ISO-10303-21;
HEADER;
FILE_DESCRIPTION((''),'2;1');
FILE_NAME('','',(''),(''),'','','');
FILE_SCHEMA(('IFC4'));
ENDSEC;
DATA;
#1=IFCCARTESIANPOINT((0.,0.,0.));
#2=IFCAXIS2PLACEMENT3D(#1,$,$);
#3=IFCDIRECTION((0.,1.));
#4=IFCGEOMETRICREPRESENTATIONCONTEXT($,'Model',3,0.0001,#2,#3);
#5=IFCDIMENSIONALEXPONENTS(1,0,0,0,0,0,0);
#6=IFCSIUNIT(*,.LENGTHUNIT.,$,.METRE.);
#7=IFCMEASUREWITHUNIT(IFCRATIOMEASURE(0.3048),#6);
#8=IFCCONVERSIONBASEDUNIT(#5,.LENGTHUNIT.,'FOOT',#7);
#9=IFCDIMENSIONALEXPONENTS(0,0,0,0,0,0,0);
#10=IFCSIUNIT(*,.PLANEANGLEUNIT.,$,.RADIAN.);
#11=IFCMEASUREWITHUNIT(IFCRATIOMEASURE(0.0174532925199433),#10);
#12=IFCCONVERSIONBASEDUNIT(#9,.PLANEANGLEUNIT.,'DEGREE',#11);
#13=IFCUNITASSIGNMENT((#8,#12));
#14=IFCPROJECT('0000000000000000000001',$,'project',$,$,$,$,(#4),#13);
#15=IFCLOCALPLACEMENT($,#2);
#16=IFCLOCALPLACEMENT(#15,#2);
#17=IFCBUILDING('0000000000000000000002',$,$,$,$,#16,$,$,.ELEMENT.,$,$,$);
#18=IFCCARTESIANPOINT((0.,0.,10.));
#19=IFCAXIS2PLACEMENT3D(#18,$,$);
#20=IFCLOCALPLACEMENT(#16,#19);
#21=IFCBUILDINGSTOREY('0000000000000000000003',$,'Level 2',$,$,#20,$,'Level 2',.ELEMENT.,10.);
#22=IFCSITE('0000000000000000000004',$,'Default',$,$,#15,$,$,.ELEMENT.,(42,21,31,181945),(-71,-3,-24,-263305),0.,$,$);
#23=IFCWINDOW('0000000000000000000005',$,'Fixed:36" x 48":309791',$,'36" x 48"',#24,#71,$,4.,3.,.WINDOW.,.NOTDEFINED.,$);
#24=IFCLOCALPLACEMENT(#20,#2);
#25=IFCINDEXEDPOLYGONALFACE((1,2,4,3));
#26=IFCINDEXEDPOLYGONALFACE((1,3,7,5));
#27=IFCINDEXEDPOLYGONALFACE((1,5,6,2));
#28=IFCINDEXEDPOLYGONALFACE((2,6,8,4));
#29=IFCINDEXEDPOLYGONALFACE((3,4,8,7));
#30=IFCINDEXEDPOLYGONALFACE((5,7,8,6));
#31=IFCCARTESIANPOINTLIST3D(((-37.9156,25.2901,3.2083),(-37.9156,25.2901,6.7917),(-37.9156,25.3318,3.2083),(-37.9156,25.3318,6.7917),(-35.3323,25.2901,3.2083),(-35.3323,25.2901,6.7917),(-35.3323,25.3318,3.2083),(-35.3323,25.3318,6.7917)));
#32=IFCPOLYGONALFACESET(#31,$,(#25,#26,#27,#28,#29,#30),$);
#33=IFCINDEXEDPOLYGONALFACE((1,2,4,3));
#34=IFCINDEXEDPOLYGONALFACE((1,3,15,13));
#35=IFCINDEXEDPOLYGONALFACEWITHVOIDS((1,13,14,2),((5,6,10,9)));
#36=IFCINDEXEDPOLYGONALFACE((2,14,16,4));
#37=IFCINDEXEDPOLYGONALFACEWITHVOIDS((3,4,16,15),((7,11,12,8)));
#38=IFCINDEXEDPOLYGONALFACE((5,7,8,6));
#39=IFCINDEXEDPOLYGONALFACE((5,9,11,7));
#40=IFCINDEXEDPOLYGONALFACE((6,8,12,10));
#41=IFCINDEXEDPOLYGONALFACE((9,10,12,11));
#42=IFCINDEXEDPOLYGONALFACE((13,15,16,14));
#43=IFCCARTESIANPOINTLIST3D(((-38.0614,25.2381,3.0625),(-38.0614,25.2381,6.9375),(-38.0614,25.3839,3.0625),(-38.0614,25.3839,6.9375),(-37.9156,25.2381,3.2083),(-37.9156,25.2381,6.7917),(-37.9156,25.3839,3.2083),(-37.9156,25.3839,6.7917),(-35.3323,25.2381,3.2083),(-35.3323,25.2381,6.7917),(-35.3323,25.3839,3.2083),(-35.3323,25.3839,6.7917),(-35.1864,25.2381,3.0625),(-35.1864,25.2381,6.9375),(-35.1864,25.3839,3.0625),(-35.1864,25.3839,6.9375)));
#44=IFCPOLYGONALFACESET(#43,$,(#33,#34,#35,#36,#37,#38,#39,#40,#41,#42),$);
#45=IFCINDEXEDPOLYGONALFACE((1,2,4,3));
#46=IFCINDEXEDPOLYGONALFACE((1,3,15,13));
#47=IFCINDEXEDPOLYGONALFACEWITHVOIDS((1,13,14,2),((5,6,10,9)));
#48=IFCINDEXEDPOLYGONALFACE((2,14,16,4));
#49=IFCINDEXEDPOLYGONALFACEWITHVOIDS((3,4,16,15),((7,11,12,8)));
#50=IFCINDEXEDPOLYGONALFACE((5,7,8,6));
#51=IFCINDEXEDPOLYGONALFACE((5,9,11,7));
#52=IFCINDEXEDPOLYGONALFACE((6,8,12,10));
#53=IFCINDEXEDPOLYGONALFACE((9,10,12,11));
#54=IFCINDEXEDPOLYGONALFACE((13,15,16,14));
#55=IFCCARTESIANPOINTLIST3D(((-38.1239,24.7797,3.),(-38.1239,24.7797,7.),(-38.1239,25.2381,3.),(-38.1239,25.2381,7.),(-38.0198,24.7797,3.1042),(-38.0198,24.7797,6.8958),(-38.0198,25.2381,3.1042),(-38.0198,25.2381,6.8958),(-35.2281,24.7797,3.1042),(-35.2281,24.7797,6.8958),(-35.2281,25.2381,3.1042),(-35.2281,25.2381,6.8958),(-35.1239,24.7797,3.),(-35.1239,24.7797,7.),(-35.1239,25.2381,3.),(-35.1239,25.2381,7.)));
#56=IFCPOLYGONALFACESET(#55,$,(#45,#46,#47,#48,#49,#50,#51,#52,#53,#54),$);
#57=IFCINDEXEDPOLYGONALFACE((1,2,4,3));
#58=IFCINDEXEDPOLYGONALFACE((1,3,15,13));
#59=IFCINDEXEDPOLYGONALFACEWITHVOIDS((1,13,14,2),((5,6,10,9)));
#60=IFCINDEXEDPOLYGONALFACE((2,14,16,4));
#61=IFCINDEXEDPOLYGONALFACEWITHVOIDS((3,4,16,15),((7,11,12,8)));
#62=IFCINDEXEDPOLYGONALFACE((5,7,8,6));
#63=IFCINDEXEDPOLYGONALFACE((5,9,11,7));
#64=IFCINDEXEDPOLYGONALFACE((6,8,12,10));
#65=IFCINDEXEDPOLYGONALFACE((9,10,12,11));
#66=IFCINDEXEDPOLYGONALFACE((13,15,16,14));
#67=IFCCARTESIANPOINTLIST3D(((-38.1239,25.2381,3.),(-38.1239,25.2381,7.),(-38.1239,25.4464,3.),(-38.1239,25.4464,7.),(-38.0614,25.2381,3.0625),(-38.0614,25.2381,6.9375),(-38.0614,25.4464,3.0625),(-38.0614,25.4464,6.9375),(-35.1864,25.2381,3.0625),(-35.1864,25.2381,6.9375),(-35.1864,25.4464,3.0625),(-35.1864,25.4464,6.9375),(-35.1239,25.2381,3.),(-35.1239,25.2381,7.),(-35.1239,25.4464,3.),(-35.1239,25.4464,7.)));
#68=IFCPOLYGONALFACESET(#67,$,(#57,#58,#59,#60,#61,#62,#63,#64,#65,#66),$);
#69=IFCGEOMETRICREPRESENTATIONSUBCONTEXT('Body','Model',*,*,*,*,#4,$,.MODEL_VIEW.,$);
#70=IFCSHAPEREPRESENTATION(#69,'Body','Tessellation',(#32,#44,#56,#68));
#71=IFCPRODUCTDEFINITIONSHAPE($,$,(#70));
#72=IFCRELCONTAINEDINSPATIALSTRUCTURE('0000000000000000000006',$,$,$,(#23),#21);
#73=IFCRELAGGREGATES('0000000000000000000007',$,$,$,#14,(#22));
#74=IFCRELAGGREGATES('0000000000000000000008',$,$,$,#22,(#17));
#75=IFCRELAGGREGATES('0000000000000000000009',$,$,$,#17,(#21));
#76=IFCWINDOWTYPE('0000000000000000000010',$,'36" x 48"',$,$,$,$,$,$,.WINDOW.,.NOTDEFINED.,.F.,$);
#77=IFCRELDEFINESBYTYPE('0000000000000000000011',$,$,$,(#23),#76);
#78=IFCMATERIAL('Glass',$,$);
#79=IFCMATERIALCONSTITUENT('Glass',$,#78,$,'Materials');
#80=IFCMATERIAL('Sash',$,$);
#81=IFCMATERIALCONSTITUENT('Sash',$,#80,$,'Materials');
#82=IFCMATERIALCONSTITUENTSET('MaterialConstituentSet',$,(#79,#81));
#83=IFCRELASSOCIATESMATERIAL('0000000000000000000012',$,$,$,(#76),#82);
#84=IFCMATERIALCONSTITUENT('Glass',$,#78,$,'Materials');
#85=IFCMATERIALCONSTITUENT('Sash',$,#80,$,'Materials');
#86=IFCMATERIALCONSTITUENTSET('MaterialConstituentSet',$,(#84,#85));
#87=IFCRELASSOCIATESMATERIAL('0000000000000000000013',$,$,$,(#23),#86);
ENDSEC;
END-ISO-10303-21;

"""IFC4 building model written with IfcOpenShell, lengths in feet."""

from ifc_helpers import new_model, entity, si_unit, converted_unit, direction, frame, frame_2d, origin, place, context, subcontext, project, spatial, polyline, rectangle, outline, extrude, source, transform, mapped, material, constituent, constituent_set, type_object, type_shapes, element, save


model = new_model("IFC4")

# Units and contexts
model_context = context("Model", 3, precision=0.0001, world=origin(), true_north=direction((0.0, 1.0)))
body_context = subcontext(model_context, "Body", "Model", "MODEL_VIEW")
ifc_project = project(units=[converted_unit("LENGTHUNIT", "FOOT", entity("IfcRatioMeasure", 0.3048), si_unit("LENGTHUNIT", "METRE"), dimensions=[1, 0, 0, 0, 0, 0, 0]), converted_unit("PLANEANGLEUNIT", "DEGREE", entity("IfcRatioMeasure", 0.0174532925199433), si_unit("PLANEANGLEUNIT", "RADIAN"), dimensions=[0, 0, 0, 0, 0, 0, 0])], contexts=[model_context])

# Site, building, storey
site_placement = place(None, origin())
site = spatial("IfcSite", under=ifc_project, at=site_placement, Name="Default", CompositionType="ELEMENT", RefLatitude=(42, 21, 31, 181945), RefLongitude=(-71, -3, -24, -263305), RefElevation=0.0)
building_placement = place(site_placement, origin())
building = spatial("IfcBuilding", under=site, at=building_placement, CompositionType="ELEMENT")
storey_placement = place(building_placement, frame((0.0, 0.0, 10.0)))
storey = spatial("IfcBuildingStorey", under=building, at=storey_placement, Name="Level 2", LongName="Level 2", CompositionType="ELEMENT", Elevation=10.0)

# Shared definitions
placement_1 = place(storey_placement, frame((-51.2906, 25.1131, 0.0)))

# Window
ifc_material_1 = material(Name="Glass")
ifc_constituent_1 = constituent(ifc_material_1, Name="Glass", Category="Materials")
ifc_material_2 = material(Name="Sash")
ifc_constituent_2 = constituent(ifc_material_2, Name="Sash", Category="Materials")
ifc_constituent_set_1 = constituent_set(constituents=[ifc_constituent_1, ifc_constituent_2], Name="MaterialConstituentSet")
ifc_constituent_3 = constituent(ifc_material_1, Name="Glass", Category="Materials")
ifc_constituent_4 = constituent(ifc_material_2, Name="Sash", Category="Materials")
ifc_constituent_set_2 = constituent_set(constituents=[ifc_constituent_3, ifc_constituent_4], Name="MaterialConstituentSet")
window_type = type_object("IfcWindowType", Name="36\" x 48\"", ParameterTakesPrecedence=False, PartitioningType="NOTDEFINED", PredefinedType="WINDOW", material=ifc_constituent_set_2)
shared_shape = source(origin(), body_context, "Body", "SweptSolid", [
    extrude(rectangle(XDim=0.0417, YDim=2.5833, at=frame_2d((0.0, 0.0), x_axis=(1.0, 0.0))), frame((1.5, 0.5312, 0.2083), z_axis=(0.0, 0.0, 1.0), x_axis=(0.0, 1.0, 0.0)), (0.0, 0.0, 1.0), 3.5833),
    extrude(outline(polyline([(-1.4375, -1.9375), (1.4375, -1.9375), (1.4375, 1.9375), (-1.4375, 1.9375), (-1.4375, -1.9375)]), holes=[polyline([(-1.2917, -1.7917), (-1.2917, 1.7917), (1.2917, 1.7917), (1.2917, -1.7917), (-1.2917, -1.7917)])]), frame((1.5, 0.4583, 2.0), z_axis=(0.0, 1.0, 0.0), x_axis=(1.0, 0.0, 0.0)), (0.0, 0.0, 1.0), 0.1458),
    extrude(outline(polyline([(-1.5, -2.0), (1.5, -2.0), (1.5, 2.0), (-1.5, 2.0), (-1.5, -2.0)]), holes=[polyline([(-1.3958, -1.8958), (-1.3958, 1.8958), (1.3958, 1.8958), (1.3958, -1.8958), (-1.3958, -1.8958)])]), frame((1.5, 0.0, 2.0), z_axis=(0.0, 1.0, 0.0), x_axis=(1.0, 0.0, 0.0)), (0.0, 0.0, 1.0), 0.4583),
    extrude(outline(polyline([(-2.0, -1.5), (2.0, -1.5), (2.0, 1.5), (-2.0, 1.5), (-2.0, -1.5)]), holes=[polyline([(-1.9375, -1.4375), (-1.9375, 1.4375), (1.9375, 1.4375), (1.9375, -1.4375), (-1.9375, -1.4375)])]), frame((1.5, 0.4583, 2.0), z_axis=(0.0, 1.0, 0.0), x_axis=(0.0, 0.0, -1.0)), (0.0, 0.0, 1.0), 0.2083),
])
type_shapes(window_type, [shared_shape])
placement_2 = place(placement_1, frame((13.1667, -0.3333, 3.0)))
window_placement = place(placement_2, origin())
element("IfcWindow", 1, at=window_placement, inside=storey, type_object=window_type, material=ifc_constituent_set_1, Name="Fixed:36\" x 48\":309791", ObjectType="36\" x 48\"", OverallHeight=4.0, OverallWidth=3.0, PartitioningType="NOTDEFINED", PredefinedType="WINDOW", context=body_context, shape_type="MappedRepresentation", body=[
    mapped(shared_shape, transform((0.0, 0.0, 0.0), scale=1.0)),
])

save(model, "model.ifc")
